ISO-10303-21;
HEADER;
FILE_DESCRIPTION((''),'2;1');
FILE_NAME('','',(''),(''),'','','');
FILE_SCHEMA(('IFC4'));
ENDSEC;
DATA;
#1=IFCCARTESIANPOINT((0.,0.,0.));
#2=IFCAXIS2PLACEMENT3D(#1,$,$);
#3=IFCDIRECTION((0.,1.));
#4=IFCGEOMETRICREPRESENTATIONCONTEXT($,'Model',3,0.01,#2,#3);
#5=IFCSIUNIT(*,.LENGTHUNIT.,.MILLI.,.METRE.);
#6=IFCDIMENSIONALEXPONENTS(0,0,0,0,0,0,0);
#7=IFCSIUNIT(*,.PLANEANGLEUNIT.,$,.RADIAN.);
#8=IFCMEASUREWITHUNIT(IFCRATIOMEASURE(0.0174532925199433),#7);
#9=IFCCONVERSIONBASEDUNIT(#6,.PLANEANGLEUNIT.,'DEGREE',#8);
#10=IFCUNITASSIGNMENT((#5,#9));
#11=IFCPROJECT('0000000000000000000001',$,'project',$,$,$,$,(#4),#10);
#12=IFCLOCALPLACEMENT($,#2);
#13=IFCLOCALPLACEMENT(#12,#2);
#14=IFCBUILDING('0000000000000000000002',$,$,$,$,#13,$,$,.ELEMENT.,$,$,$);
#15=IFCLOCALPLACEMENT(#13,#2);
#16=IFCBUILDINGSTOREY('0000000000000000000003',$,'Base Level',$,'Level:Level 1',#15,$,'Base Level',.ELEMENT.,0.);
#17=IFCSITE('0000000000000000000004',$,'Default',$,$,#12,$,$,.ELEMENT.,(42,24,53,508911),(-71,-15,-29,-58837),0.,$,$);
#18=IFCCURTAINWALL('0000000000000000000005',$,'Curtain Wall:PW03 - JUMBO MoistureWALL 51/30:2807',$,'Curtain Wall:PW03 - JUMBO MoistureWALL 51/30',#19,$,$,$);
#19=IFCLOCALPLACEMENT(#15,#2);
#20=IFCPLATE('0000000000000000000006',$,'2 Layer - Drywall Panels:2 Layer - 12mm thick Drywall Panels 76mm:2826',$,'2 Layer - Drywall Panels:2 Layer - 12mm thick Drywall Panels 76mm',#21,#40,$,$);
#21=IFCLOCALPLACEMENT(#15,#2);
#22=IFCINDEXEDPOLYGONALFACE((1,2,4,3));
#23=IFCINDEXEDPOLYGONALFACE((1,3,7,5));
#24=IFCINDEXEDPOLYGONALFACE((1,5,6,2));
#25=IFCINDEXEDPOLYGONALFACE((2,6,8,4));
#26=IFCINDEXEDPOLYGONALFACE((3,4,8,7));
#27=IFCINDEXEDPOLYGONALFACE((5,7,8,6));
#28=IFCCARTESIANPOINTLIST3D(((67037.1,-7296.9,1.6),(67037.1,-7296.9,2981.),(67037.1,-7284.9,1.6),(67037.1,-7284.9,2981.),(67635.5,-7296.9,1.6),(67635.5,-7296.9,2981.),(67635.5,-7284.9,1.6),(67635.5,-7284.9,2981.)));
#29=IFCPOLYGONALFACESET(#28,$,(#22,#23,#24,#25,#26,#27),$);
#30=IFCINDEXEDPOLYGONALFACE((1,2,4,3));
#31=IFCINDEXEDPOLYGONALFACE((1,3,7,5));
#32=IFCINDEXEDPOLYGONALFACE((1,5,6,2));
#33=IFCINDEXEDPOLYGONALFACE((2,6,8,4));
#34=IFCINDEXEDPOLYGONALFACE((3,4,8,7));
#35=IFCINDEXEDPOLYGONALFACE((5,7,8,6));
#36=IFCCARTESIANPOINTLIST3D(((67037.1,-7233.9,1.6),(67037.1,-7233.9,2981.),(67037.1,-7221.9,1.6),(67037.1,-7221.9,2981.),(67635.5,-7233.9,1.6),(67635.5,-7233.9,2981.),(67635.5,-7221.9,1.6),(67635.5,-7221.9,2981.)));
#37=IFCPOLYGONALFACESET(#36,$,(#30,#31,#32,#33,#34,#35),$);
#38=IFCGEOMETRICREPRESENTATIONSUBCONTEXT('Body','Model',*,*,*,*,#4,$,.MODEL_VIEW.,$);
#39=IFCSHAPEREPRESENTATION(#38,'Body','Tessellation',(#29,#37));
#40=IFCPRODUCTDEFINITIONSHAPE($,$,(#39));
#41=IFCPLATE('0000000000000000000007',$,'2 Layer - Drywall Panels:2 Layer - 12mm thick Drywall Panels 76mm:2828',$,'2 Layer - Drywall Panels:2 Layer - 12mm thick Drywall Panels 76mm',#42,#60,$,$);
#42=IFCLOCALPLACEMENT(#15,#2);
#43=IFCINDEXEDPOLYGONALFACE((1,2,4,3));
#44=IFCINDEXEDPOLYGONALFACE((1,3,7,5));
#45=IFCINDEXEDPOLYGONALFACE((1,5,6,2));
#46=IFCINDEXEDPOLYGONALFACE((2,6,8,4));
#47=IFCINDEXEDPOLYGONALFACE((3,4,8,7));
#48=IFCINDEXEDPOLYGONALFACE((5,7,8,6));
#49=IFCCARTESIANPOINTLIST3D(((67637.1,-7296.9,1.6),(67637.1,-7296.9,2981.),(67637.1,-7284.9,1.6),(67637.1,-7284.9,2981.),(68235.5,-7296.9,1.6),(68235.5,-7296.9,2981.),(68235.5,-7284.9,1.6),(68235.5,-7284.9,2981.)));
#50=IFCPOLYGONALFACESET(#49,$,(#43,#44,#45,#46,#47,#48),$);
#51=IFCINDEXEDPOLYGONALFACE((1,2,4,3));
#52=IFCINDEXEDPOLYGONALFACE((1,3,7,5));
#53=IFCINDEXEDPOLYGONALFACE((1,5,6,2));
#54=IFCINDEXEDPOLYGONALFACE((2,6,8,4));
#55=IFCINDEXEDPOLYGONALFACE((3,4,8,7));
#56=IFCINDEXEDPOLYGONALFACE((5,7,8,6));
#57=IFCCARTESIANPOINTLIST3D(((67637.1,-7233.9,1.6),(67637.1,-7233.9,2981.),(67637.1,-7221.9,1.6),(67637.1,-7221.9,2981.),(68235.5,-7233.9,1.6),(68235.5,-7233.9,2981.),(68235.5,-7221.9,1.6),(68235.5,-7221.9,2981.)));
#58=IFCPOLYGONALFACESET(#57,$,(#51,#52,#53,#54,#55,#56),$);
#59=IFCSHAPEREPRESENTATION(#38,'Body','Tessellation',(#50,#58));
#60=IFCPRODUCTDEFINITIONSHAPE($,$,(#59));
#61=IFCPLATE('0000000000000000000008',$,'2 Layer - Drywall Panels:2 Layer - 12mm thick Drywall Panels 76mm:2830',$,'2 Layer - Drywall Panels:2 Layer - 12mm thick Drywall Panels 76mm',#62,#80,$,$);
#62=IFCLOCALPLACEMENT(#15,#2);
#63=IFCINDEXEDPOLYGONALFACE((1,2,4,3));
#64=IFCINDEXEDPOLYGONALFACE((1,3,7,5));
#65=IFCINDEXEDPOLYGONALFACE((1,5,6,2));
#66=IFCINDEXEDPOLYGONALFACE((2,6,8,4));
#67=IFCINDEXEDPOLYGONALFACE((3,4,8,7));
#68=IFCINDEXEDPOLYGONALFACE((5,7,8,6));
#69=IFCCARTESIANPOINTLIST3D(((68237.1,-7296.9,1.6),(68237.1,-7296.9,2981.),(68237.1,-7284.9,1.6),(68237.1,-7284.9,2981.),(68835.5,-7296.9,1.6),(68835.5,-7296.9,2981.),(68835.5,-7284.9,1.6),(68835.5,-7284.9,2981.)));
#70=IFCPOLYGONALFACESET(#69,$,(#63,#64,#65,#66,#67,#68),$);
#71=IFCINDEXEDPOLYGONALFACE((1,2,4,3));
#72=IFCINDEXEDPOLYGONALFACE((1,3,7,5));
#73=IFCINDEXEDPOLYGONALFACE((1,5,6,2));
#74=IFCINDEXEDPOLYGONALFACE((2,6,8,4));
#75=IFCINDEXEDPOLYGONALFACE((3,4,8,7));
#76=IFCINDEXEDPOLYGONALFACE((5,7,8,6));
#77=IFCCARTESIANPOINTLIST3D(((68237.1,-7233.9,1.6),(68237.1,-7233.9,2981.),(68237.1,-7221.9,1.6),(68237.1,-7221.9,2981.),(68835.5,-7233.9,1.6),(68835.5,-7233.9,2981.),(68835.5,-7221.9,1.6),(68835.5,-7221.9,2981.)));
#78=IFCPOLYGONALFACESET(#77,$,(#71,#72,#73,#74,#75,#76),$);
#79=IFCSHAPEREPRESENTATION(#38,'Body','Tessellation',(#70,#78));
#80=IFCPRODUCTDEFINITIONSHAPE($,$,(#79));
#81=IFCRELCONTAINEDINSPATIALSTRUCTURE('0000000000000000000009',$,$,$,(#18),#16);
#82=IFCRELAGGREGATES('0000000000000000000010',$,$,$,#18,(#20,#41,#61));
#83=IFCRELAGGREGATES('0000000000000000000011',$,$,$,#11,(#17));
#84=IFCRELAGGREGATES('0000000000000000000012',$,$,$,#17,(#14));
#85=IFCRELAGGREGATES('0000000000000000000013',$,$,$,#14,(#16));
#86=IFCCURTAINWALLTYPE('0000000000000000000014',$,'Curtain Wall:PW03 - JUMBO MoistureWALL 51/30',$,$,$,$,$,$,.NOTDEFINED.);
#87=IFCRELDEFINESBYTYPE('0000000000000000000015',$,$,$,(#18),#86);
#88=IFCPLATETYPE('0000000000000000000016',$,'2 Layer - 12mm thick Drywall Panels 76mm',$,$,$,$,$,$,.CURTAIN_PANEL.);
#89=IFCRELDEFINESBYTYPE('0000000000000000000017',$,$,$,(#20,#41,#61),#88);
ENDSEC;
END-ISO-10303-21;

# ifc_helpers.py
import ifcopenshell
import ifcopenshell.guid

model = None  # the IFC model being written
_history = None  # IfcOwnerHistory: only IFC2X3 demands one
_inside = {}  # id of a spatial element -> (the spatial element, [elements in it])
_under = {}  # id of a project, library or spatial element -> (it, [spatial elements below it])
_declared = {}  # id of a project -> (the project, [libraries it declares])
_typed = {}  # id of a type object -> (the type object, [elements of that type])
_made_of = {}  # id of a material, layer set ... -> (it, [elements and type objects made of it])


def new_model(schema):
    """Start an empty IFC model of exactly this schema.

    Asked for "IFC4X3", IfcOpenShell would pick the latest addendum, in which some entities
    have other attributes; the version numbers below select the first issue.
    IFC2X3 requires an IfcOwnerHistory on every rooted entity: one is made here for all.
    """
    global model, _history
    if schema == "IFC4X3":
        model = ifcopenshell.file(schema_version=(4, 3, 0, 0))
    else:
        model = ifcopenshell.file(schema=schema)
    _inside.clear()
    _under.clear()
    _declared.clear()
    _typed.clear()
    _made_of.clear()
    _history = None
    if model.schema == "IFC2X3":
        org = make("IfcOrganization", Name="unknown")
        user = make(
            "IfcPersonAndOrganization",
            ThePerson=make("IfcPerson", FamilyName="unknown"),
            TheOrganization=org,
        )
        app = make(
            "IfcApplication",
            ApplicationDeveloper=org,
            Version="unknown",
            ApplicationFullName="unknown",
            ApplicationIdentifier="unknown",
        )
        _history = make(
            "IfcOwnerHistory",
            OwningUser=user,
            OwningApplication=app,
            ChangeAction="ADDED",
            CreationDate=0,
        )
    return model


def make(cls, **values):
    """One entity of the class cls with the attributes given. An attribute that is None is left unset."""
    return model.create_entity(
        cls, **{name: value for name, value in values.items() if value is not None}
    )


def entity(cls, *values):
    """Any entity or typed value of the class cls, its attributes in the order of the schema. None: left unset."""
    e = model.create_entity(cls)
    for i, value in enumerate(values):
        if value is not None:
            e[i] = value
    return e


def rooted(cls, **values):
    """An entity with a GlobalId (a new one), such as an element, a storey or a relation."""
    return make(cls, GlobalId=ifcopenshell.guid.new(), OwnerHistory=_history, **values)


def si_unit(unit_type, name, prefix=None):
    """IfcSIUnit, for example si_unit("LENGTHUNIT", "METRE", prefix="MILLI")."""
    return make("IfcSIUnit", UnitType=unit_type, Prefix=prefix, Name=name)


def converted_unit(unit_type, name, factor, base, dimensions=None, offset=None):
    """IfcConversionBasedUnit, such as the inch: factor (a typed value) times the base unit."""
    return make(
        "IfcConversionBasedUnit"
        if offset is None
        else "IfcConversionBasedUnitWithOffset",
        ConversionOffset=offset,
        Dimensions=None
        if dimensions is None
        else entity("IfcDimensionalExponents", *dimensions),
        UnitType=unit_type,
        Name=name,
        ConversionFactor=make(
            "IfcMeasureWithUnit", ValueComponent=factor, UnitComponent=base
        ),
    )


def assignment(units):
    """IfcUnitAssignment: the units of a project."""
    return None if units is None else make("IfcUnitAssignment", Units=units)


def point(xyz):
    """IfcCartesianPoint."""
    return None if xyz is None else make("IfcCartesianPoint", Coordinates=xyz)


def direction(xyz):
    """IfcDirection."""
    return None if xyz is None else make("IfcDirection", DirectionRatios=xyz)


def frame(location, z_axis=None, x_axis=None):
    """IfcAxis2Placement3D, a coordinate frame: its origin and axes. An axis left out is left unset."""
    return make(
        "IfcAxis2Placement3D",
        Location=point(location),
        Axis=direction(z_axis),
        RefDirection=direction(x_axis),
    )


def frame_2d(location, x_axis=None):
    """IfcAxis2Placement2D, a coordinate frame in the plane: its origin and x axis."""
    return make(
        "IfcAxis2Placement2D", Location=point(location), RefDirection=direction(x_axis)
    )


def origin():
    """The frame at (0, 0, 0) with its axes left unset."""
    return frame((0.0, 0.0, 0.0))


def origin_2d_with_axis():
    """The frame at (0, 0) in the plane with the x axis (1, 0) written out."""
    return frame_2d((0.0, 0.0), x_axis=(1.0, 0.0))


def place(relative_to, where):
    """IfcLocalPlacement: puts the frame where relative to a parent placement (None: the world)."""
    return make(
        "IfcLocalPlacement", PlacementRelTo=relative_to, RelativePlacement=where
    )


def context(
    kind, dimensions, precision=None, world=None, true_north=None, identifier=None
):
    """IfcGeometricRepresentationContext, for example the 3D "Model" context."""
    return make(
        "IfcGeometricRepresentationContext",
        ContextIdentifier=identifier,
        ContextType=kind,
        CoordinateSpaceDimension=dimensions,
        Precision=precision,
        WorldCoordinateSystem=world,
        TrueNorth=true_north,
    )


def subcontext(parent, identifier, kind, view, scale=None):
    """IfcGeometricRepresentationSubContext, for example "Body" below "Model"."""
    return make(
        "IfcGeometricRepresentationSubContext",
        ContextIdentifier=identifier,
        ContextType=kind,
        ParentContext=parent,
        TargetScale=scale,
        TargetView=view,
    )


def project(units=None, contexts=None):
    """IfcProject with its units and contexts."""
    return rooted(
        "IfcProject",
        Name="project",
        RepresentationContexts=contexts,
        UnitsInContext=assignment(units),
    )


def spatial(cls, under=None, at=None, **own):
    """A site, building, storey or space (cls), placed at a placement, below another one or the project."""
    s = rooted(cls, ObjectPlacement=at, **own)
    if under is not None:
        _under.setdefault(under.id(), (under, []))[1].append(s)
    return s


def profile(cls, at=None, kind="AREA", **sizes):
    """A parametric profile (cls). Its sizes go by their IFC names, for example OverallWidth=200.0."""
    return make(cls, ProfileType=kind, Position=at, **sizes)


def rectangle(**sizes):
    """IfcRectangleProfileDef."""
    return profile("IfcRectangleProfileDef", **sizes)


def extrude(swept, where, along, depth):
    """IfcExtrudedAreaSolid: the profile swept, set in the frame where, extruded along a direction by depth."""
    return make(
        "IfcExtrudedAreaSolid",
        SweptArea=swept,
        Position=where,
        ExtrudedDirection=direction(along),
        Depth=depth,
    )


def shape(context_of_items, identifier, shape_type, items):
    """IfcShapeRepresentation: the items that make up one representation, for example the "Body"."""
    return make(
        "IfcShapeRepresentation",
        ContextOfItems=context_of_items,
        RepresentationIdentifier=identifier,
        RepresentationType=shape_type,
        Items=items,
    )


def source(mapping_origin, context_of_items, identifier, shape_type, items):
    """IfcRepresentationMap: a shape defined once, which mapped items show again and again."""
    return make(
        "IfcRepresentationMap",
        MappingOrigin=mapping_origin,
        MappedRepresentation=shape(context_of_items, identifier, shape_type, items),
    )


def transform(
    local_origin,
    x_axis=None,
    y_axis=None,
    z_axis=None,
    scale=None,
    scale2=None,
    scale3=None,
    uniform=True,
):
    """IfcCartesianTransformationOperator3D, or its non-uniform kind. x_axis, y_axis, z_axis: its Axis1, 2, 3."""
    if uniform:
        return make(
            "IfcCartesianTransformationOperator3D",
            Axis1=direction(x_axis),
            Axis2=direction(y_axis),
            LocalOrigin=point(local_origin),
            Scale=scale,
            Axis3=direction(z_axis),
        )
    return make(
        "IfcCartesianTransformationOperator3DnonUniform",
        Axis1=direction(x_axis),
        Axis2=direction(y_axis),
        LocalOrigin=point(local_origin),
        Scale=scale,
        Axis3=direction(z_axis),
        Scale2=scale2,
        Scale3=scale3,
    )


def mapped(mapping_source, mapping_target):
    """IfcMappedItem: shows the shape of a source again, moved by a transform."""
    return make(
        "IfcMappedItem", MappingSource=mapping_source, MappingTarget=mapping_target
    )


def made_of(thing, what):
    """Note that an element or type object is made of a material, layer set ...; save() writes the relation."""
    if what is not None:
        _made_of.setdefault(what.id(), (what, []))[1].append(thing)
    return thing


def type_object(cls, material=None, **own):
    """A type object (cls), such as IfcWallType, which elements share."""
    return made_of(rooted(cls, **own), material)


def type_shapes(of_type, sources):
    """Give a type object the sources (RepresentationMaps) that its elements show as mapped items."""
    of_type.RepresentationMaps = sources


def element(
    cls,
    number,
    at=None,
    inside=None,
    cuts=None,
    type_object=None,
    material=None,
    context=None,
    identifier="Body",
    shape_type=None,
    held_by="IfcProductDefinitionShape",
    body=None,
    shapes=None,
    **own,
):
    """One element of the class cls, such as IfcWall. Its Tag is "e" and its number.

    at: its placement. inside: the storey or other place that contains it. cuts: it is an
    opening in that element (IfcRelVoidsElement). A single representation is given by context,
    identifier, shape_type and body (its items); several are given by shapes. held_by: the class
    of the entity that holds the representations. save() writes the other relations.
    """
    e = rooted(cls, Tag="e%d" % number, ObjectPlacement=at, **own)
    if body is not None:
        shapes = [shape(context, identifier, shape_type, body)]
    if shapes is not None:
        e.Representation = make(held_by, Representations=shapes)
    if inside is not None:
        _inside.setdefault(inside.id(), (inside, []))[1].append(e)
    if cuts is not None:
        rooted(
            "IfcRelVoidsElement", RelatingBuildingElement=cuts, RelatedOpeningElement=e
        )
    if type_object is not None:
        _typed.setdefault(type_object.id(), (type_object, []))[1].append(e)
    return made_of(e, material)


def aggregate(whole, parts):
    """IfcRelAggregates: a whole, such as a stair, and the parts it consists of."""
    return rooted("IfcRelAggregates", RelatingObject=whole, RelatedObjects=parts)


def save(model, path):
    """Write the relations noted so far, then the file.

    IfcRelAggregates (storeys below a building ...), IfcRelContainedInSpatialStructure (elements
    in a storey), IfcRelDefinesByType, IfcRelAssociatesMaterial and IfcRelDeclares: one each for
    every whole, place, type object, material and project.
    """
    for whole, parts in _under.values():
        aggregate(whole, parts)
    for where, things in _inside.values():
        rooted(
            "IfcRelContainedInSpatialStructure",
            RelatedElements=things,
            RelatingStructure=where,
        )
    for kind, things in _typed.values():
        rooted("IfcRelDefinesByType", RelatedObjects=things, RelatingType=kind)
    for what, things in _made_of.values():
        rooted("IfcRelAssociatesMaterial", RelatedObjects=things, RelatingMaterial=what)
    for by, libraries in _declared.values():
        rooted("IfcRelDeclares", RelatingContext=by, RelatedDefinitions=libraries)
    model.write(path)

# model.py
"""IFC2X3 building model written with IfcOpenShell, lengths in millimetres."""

from ifc_helpers import new_model, entity, si_unit, converted_unit, direction, frame, frame_2d, origin, origin_2d_with_axis, place, context, subcontext, project, spatial, rectangle, extrude, source, transform, mapped, type_object, type_shapes, element, aggregate, save


model = new_model("IFC2X3")

# Units and contexts
model_context = context("Model", 3, precision=0.01, world=origin(), true_north=direction((0.0, 1.0)))
body_context = subcontext(model_context, "Body", "Model", "MODEL_VIEW")
ifc_project = project(units=[si_unit("LENGTHUNIT", "METRE", prefix="MILLI"), converted_unit("PLANEANGLEUNIT", "DEGREE", entity("IfcRatioMeasure", 0.0174532925199433), si_unit("PLANEANGLEUNIT", "RADIAN"), dimensions=[0, 0, 0, 0, 0, 0, 0])], contexts=[model_context])

# Site, building, storey
site_placement = place(None, origin())
site = spatial("IfcSite", under=ifc_project, at=site_placement, Name="Default", CompositionType="ELEMENT", RefLatitude=(42, 24, 53, 508911), RefLongitude=(-71, -15, -29, -58837), RefElevation=0.0)
building_placement = place(site_placement, origin())
building = spatial("IfcBuilding", under=site, at=building_placement, CompositionType="ELEMENT")
storey_placement = place(building_placement, origin())
storey = spatial("IfcBuildingStorey", under=building, at=storey_placement, Name="Base Level", ObjectType="Level:Level 1", LongName="Base Level", CompositionType="ELEMENT", Elevation=0.0)

# Curtain wall, plates
curtain_wall_type = type_object("IfcCurtainWallType", Name="Curtain Wall:PW03 - JUMBO MoistureWALL 51/30", PredefinedType="NOTDEFINED")
curtain_wall_placement = place(building_placement, origin())
curtain_wall = element("IfcCurtainWall", 1, at=curtain_wall_placement, inside=storey, type_object=curtain_wall_type, Name="Curtain Wall:PW03 - JUMBO MoistureWALL 51/30:2807", ObjectType="Curtain Wall:PW03 - JUMBO MoistureWALL 51/30")
plate_type = type_object("IfcPlateType", Name="2 Layer - 12mm thick Drywall Panels 76mm", PredefinedType="CURTAIN_PANEL")
shared_shape_1 = source(origin(), body_context, "Body", "SweptSolid", [
    extrude(rectangle(XDim=598.4, YDim=12.0, at=origin_2d_with_axis()), frame((0.0, -31.5, 0.0), z_axis=(0.0, 0.0, 1.0), x_axis=(-1.0, 0.0, 0.0)), (0.0, 0.0, 1.0), 2979.4),
    extrude(rectangle(XDim=12.0, YDim=598.4, at=frame_2d((0.0, 0.0), x_axis=(1.0, 0.0))), frame((0.0, 31.5, 0.0), z_axis=(0.0, 0.0, 1.0), x_axis=(0.0, 1.0, 0.0)), (0.0, 0.0, 1.0), 2979.4),
])
type_shapes(plate_type, [shared_shape_1])
plate_1_placement = place(curtain_wall_placement, frame((67336.3, -7259.4, 1.6)))
plate_1 = element("IfcPlate", 2, at=plate_1_placement, type_object=plate_type, Name="2 Layer - Drywall Panels:2 Layer - 12mm thick Drywall Panels 76mm:2826", ObjectType="2 Layer - Drywall Panels:2 Layer - 12mm thick Drywall Panels 76mm", context=body_context, shape_type="MappedRepresentation", body=[
    mapped(shared_shape_1, transform((0.0, 0.0, 0.0), scale=1.0)),
])
plate_2_placement = place(curtain_wall_placement, frame((67936.3, -7259.4, 1.6)))
plate_2 = element("IfcPlate", 3, at=plate_2_placement, type_object=plate_type, Name="2 Layer - Drywall Panels:2 Layer - 12mm thick Drywall Panels 76mm:2828", ObjectType="2 Layer - Drywall Panels:2 Layer - 12mm thick Drywall Panels 76mm", context=body_context, shape_type="MappedRepresentation", body=[
    mapped(shared_shape_1, transform((0.0, 0.0, 0.0), scale=1.0)),
])
plate_3_placement = place(curtain_wall_placement, frame((68536.3, -7259.4, 1.6)))
plate_3 = element("IfcPlate", 4, at=plate_3_placement, type_object=plate_type, Name="2 Layer - Drywall Panels:2 Layer - 12mm thick Drywall Panels 76mm:2830", ObjectType="2 Layer - Drywall Panels:2 Layer - 12mm thick Drywall Panels 76mm", context=body_context, shape_type="MappedRepresentation", body=[
    mapped(shared_shape_1, transform((0.0, 0.0, 0.0), scale=1.0)),
])
aggregate(curtain_wall, [plate_1, plate_2, plate_3])

save(model, "model.ifc")
